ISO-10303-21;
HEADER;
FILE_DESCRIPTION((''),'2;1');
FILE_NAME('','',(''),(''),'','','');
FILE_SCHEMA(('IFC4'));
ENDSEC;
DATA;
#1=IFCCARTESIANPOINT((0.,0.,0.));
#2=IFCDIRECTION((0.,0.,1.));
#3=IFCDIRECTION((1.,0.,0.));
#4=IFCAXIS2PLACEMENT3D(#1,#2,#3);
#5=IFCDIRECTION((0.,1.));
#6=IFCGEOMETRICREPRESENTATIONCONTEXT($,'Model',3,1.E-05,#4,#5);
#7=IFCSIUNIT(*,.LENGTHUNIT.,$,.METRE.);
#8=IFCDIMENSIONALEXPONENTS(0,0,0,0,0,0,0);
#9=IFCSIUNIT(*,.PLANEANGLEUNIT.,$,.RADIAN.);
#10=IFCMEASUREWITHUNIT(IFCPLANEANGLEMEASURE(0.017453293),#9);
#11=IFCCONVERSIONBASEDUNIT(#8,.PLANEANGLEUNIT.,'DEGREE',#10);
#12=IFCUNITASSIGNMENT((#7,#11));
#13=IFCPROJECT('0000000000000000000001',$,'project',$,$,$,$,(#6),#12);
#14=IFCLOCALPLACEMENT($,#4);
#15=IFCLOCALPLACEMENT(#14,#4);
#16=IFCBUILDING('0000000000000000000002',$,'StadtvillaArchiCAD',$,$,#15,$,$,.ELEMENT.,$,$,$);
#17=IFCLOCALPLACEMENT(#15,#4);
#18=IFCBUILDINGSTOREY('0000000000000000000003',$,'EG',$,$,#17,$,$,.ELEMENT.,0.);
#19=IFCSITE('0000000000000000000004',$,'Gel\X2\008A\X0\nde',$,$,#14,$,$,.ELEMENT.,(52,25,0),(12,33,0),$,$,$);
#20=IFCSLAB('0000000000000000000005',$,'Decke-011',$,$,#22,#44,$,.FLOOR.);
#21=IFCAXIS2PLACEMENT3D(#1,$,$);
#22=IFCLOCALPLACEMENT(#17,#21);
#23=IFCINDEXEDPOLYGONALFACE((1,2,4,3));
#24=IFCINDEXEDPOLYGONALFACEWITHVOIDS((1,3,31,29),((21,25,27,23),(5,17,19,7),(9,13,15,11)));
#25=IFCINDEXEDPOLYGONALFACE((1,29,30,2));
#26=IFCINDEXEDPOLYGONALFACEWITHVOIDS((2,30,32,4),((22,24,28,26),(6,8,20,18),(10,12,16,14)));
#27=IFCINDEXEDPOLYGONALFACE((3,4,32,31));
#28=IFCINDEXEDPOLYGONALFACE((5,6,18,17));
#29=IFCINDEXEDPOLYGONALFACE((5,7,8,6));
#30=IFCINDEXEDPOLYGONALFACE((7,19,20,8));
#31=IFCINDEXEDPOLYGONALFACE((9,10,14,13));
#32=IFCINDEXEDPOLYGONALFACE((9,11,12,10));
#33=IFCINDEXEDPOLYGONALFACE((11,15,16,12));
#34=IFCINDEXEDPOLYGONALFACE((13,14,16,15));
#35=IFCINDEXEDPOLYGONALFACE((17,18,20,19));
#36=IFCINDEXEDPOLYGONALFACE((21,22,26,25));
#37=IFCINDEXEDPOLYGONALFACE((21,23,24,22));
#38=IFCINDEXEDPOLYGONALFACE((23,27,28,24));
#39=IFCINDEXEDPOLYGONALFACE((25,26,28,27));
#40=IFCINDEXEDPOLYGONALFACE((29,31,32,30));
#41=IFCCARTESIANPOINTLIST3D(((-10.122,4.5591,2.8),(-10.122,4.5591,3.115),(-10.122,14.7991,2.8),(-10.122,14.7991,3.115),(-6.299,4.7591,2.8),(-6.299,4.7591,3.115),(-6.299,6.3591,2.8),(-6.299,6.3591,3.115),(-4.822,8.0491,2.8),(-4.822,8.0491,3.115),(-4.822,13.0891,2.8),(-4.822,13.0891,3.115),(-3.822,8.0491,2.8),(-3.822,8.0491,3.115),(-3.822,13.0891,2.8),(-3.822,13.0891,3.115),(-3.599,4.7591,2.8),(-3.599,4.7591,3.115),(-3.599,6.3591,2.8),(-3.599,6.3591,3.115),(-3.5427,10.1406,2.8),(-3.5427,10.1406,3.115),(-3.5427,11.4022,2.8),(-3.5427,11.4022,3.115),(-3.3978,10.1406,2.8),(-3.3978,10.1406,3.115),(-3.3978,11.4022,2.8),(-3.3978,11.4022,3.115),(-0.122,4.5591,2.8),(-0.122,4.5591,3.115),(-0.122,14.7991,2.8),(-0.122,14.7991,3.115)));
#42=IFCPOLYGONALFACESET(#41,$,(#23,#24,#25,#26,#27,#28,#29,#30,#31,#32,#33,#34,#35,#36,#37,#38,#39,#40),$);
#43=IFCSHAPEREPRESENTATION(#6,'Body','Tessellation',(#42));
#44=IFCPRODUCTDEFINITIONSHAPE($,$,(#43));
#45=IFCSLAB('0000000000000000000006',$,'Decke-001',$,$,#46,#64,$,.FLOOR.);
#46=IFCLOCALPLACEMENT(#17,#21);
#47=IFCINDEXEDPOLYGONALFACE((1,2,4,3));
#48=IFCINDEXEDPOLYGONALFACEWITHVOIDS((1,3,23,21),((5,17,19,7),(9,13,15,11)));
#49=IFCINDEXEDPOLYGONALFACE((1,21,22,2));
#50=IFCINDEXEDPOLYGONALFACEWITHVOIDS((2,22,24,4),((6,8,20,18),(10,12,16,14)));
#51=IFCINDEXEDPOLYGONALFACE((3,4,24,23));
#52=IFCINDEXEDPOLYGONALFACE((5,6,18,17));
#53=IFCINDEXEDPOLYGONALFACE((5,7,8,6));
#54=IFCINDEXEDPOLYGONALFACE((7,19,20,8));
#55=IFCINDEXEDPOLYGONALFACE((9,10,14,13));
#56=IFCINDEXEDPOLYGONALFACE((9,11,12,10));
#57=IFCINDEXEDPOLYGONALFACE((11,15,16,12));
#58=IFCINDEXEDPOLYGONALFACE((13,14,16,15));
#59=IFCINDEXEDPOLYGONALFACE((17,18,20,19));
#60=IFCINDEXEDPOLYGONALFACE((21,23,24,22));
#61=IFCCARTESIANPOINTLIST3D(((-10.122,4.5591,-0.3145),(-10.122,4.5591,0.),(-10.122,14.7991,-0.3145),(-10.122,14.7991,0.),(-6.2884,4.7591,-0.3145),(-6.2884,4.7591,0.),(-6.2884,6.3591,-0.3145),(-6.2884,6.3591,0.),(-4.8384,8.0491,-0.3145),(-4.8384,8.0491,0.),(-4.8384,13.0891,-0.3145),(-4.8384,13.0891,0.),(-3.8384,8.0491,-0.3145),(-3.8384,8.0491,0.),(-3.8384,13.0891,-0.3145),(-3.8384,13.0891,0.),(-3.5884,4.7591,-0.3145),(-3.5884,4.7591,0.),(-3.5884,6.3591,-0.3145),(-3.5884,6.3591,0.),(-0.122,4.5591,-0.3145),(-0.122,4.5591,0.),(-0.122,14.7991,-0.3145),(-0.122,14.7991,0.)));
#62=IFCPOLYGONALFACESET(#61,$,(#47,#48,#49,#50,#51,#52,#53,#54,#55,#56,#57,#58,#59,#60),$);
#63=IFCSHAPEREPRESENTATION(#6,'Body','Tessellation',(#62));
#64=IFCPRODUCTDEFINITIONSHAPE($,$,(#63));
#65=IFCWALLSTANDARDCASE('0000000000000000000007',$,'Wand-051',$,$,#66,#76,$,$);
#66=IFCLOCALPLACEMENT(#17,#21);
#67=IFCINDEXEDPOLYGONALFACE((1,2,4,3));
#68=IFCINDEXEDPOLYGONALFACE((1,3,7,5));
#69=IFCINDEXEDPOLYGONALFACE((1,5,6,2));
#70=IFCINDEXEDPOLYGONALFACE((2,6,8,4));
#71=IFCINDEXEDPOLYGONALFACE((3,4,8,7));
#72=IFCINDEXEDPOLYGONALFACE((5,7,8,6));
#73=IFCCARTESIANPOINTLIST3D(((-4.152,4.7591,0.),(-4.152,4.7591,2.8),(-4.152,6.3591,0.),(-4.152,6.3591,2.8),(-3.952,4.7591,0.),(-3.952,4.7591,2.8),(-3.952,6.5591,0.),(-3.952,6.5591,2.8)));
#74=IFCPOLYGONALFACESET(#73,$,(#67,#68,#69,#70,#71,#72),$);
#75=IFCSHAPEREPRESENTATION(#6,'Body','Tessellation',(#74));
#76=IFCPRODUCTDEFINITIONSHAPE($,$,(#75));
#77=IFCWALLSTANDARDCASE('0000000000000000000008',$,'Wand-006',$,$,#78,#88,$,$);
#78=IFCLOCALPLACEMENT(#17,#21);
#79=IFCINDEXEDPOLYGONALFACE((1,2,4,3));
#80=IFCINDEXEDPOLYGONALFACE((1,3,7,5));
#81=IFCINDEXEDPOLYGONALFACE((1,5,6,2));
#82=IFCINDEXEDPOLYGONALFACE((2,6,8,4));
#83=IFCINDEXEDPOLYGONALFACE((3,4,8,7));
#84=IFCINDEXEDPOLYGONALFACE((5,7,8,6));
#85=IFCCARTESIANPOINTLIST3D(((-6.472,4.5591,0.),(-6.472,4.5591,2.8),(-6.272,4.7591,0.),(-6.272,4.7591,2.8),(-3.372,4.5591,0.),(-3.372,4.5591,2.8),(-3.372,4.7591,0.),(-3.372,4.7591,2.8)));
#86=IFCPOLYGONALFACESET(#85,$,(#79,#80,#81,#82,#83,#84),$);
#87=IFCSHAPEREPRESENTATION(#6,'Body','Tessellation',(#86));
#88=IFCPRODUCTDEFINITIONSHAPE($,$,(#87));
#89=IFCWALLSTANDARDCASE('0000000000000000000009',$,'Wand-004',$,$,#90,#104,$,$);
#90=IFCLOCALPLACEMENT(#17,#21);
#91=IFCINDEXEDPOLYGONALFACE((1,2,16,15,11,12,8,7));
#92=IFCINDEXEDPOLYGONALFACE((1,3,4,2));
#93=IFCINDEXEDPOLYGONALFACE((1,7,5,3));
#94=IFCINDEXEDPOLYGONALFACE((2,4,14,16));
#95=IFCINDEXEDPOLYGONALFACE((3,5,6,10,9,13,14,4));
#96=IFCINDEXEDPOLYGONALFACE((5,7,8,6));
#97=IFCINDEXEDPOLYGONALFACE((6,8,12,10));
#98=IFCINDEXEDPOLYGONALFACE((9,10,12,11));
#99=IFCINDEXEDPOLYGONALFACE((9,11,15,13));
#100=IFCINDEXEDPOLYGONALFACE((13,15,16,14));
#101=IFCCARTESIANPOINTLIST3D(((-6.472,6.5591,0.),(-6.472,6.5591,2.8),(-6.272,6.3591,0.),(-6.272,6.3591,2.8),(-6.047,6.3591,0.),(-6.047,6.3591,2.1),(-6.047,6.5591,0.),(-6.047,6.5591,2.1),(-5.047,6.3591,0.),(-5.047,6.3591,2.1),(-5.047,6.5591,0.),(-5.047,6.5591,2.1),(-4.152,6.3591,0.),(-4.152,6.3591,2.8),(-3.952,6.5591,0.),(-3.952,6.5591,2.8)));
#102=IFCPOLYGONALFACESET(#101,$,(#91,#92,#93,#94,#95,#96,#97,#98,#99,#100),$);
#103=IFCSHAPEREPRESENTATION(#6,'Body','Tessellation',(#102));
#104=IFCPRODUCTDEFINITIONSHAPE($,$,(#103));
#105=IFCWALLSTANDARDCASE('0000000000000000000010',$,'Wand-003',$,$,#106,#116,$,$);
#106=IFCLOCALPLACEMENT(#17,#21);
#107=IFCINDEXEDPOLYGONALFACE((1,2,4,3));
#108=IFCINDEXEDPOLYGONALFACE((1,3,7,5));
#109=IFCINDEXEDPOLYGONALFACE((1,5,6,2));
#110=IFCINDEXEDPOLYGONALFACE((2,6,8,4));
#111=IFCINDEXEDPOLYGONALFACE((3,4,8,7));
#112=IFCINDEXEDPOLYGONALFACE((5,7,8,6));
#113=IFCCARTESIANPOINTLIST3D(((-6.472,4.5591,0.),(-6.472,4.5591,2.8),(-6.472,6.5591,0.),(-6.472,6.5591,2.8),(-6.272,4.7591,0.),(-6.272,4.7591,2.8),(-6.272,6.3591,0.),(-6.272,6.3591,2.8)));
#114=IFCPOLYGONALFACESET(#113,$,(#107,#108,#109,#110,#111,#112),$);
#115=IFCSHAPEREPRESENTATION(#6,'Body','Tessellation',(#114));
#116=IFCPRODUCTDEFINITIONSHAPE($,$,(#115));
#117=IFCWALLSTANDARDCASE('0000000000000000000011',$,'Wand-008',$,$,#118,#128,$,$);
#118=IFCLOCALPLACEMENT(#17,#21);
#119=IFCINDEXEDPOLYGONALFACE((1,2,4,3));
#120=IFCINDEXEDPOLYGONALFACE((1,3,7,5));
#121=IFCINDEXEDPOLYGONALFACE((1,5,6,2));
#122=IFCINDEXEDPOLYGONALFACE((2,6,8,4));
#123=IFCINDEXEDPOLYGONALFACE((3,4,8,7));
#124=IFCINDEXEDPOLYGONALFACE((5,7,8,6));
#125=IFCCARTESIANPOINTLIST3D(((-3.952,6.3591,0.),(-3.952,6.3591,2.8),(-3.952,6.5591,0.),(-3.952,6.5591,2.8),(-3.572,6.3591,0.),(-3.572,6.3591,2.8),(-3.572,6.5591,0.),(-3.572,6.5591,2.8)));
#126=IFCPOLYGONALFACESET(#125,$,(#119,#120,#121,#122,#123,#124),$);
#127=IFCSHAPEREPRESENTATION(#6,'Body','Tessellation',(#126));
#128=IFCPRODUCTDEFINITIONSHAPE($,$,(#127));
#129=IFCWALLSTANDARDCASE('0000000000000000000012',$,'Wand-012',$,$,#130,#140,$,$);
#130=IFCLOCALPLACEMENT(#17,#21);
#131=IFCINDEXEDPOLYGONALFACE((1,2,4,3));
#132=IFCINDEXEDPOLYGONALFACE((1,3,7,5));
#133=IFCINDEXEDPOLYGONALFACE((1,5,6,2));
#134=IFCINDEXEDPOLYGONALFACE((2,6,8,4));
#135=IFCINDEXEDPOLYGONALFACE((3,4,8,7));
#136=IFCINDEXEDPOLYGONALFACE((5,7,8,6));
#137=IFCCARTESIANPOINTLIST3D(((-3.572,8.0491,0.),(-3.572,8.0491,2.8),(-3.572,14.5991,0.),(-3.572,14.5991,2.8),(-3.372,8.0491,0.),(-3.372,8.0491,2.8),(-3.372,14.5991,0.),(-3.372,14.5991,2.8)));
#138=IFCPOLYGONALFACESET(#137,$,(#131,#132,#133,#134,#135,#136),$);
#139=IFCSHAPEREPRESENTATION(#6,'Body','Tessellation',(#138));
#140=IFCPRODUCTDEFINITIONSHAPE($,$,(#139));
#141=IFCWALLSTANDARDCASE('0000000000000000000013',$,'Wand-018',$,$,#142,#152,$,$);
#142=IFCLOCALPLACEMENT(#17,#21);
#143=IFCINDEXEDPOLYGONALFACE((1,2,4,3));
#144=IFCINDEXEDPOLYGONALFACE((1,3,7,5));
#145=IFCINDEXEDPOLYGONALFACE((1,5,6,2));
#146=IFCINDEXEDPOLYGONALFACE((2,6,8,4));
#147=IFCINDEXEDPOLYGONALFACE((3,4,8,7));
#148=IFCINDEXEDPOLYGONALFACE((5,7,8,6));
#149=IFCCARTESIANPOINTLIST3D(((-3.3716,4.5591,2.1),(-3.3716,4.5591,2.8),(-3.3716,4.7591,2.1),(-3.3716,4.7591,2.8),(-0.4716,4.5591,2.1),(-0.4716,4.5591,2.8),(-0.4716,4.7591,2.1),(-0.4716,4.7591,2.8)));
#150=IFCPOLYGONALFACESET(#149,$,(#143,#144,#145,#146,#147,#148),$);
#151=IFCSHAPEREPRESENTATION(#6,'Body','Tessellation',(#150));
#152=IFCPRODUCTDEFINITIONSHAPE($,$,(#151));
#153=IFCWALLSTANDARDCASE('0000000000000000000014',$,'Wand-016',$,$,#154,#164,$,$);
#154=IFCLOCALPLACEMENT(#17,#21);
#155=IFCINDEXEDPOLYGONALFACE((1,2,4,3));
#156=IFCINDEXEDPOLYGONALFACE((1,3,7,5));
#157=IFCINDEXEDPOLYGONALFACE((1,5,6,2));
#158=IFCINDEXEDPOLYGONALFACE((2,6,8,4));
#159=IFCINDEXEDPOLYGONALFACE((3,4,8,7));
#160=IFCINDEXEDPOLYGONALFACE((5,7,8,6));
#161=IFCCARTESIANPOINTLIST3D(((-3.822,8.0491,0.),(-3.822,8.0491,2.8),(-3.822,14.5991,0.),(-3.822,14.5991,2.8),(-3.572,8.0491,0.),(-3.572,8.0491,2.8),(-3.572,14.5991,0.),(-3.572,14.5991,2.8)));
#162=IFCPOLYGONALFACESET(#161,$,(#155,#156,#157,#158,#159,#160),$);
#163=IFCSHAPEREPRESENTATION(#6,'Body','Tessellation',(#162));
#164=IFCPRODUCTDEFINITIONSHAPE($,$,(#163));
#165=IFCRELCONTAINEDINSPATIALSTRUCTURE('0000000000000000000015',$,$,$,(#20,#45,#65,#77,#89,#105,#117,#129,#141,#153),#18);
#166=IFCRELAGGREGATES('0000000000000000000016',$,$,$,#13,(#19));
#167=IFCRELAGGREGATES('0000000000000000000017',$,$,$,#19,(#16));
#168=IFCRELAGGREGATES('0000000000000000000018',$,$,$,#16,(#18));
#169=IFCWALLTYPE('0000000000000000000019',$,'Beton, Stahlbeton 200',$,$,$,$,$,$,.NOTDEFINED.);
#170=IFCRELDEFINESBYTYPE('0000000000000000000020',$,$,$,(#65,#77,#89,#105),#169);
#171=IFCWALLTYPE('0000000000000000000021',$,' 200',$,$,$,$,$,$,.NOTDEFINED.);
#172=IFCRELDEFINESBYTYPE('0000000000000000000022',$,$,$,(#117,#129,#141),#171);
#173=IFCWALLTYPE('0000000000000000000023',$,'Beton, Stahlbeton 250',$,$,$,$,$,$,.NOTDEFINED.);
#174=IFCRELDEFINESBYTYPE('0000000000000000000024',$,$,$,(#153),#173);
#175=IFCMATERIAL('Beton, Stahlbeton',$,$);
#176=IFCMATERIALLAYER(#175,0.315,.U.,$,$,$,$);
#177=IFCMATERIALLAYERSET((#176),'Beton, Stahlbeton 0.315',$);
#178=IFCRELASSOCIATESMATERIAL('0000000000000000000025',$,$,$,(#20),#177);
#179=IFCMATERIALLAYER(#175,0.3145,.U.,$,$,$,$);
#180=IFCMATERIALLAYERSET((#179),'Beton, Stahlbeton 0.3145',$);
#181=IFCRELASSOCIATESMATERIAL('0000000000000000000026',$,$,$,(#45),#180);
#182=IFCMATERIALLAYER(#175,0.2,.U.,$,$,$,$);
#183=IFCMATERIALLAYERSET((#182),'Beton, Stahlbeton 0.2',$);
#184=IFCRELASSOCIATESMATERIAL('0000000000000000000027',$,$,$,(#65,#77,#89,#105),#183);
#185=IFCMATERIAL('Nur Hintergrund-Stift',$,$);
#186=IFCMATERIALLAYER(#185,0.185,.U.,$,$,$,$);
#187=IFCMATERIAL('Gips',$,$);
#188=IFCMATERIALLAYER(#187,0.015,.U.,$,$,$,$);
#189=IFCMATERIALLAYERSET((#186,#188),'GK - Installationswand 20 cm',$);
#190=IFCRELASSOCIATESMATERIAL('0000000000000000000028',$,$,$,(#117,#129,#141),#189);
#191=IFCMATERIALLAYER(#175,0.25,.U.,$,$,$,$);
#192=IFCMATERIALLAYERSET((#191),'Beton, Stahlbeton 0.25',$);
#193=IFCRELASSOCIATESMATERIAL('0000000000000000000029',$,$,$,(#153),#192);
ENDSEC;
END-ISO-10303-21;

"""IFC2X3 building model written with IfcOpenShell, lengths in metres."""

from ifc_helpers import new_model, entity, si_unit, converted_unit, direction, frame, origin_with_axes, origin_2d_with_axis, place, context, project, spatial, polyline, rectangle, outline, extrude, material, layer, layer_set, layer_usage, type_object, element, save


model = new_model("IFC2X3")

# Units and contexts
model_context = context("Model", 3, precision=1e-05, world=origin_with_axes(), true_north=direction((0.0, 1.0)))
ifc_project = project(units=[si_unit("LENGTHUNIT", "METRE"), converted_unit("PLANEANGLEUNIT", "DEGREE", entity("IfcPlaneAngleMeasure", 0.017453293), si_unit("PLANEANGLEUNIT", "RADIAN"), dimensions=[0, 0, 0, 0, 0, 0, 0])], contexts=[model_context])

# Site, building, storey
site_placement = place(None, origin_with_axes())
site = spatial("IfcSite", under=ifc_project, at=site_placement, Name="Gel\u008ande", CompositionType="ELEMENT", RefLatitude=(52, 25, 0), RefLongitude=(12, 33, 0))
building_placement = place(site_placement, origin_with_axes())
building = spatial("IfcBuilding", under=site, at=building_placement, Name="StadtvillaArchiCAD", CompositionType="ELEMENT")
storey_placement = place(building_placement, origin_with_axes())
storey = spatial("IfcBuildingStorey", under=building, at=storey_placement, Name="EG", CompositionType="ELEMENT", Elevation=0.0)

# Slabs
ifc_material_1 = material(Name="Beton, Stahlbeton")
ifc_layer_1 = layer(ifc_material_1, 0.315, ventilated="UNKNOWN")
ifc_layer_set_1 = layer_set([ifc_layer_1], Name="Beton, Stahlbeton 0.315")
ifc_layer_usage_1 = layer_usage(ifc_layer_set_1, "AXIS3", "NEGATIVE", 0.315)
slab_1_placement = place(storey_placement, frame((-0.122, 14.7991, 2.8), z_axis=(0.0, 0.0, 1.0), x_axis=(1.0, 0.0, 0.0)))
element("IfcSlab", 1, at=slab_1_placement, inside=storey, material=ifc_layer_usage_1, Name="Decke-011", PredefinedType="FLOOR", context=model_context, shape_type="SweptSolid", body=[
    extrude(outline(polyline([(0.0, 0.0), (-10.0, 0.0), (-10.0, -10.24), (0.0, -10.24), (0.0, 0.0)]), holes=[polyline([(-4.7, -1.71), (-3.7, -1.71), (-3.7, -6.75), (-4.7, -6.75), (-4.7, -1.71)]), polyline([(-3.4208, -3.3969), (-3.2759, -3.3969), (-3.2759, -4.6585), (-3.4208, -4.6585), (-3.4208, -3.3969)]), polyline([(-6.1771, -8.44), (-3.4771, -8.44), (-3.4771, -10.04), (-6.1771, -10.04), (-6.1771, -8.44)])]), origin_with_axes(), (0.0, 0.0, 1.0), 0.315),
])
ifc_layer_2 = layer(ifc_material_1, 0.3145, ventilated="UNKNOWN")
ifc_layer_set_2 = layer_set([ifc_layer_2], Name="Beton, Stahlbeton 0.3145")
ifc_layer_usage_2 = layer_usage(ifc_layer_set_2, "AXIS3", "NEGATIVE", 0.3145)
slab_2_placement = place(storey_placement, frame((-10.122, 14.7991, -0.3145), z_axis=(0.0, 0.0, 1.0), x_axis=(1.0, 0.0, 0.0)))
element("IfcSlab", 2, at=slab_2_placement, inside=storey, material=ifc_layer_usage_2, Name="Decke-001", PredefinedType="FLOOR", context=model_context, shape_type="SweptSolid", body=[
    extrude(outline(polyline([(0.0, 0.0), (0.0, -10.24), (10.0, -10.24), (10.0, 0.0), (0.0, 0.0)]), holes=[polyline([(5.2835, -1.71), (6.2835, -1.71), (6.2835, -6.75), (5.2835, -6.75), (5.2835, -1.71)]), polyline([(3.8335, -8.44), (6.5335, -8.44), (6.5335, -10.04), (3.8335, -10.04), (3.8335, -8.44)])]), origin_with_axes(), (0.0, 0.0, 1.0), 0.3145),
])

# Walls
ifc_layer_3 = layer(ifc_material_1, 0.2, ventilated="UNKNOWN")
ifc_layer_set_3 = layer_set([ifc_layer_3], Name="Beton, Stahlbeton 0.2")
ifc_layer_usage_3 = layer_usage(ifc_layer_set_3, "AXIS2", "NEGATIVE", 0.0)
wall_type_1 = type_object("IfcWallType", Name="Beton, Stahlbeton 200", PredefinedType="NOTDEFINED")
wall_1_placement = place(storey_placement, frame((-3.952, 6.5591, 0.0), z_axis=(0.0, 0.0, 1.0), x_axis=(0.0, -1.0, 0.0)))
element("IfcWallStandardCase", 3, at=wall_1_placement, inside=storey, type_object=wall_type_1, material=ifc_layer_usage_3, Name="Wand-051", context=model_context, shape_type="SweptSolid", body=[
    extrude(outline(polyline([(0.2, -0.2), (1.8, -0.2), (1.8, 0.0), (0.0, 0.0), (0.2, -0.2)])), origin_with_axes(), (0.0, 0.0, 1.0), 2.8),
])
ifc_layer_usage_4 = layer_usage(ifc_layer_set_3, "AXIS2", "NEGATIVE", 0.0)
wall_2_placement = place(storey_placement, frame((-3.372, 4.5591, 0.0), z_axis=(0.0, 0.0, 1.0), x_axis=(-1.0, 0.0, 0.0)))
element("IfcWallStandardCase", 4, at=wall_2_placement, inside=storey, type_object=wall_type_1, material=ifc_layer_usage_4, Name="Wand-006", context=model_context, shape_type="SweptSolid", body=[
    extrude(outline(polyline([(0.0, -0.2), (2.9, -0.2), (3.1, 0.0), (0.0, 0.0), (0.0, -0.2)])), origin_with_axes(), (0.0, 0.0, 1.0), 2.8),
])

# Wall, opening
ifc_layer_usage_5 = layer_usage(ifc_layer_set_3, "AXIS2", "NEGATIVE", 0.0)
wall_3_placement = place(storey_placement, frame((-6.472, 6.5591, 0.0), z_axis=(0.0, 0.0, 1.0), x_axis=(1.0, 0.0, 0.0)))
wall_3 = element("IfcWallStandardCase", 5, at=wall_3_placement, inside=storey, type_object=wall_type_1, material=ifc_layer_usage_5, Name="Wand-004", context=model_context, shape_type="SweptSolid", body=[
    extrude(outline(polyline([(0.2, -0.2), (2.32, -0.2), (2.52, 0.0), (0.0, 0.0), (0.2, -0.2)])), origin_with_axes(), (0.0, 0.0, 1.0), 2.8),
])
opening_1_placement = place(wall_3_placement, frame((0.925, 0.0, 0.0), z_axis=(0.0, 0.0, 1.0), x_axis=(1.0, 0.0, 0.0)))
element("IfcOpeningElement", 6, at=opening_1_placement, cuts=wall_3, context=model_context, shape_type="SweptSolid", body=[
    extrude(rectangle(XDim=1.0, YDim=2.1, at=origin_2d_with_axis()), frame((0.0, -1.8, 1.05), z_axis=(0.0, 1.0, 0.0), x_axis=(1.0, 0.0, 0.0)), (0.0, 0.0, 1.0), 3.2),
])

# Wall
ifc_layer_usage_6 = layer_usage(ifc_layer_set_3, "AXIS2", "NEGATIVE", 0.0)
wall_4_placement = place(storey_placement, frame((-6.472, 4.5591, 0.0), z_axis=(0.0, 0.0, 1.0), x_axis=(0.0, 1.0, 0.0)))
element("IfcWallStandardCase", 7, at=wall_4_placement, inside=storey, type_object=wall_type_1, material=ifc_layer_usage_6, Name="Wand-003", context=model_context, shape_type="SweptSolid", body=[
    extrude(outline(polyline([(0.2, -0.2), (1.8, -0.2), (2.0, 0.0), (0.0, 0.0), (0.2, -0.2)])), origin_with_axes(), (0.0, 0.0, 1.0), 2.8),
])

# Walls
ifc_material_2 = material(Name="Nur Hintergrund-Stift")
ifc_layer_4 = layer(ifc_material_2, 0.185, ventilated="UNKNOWN")
ifc_material_3 = material(Name="Gips")
ifc_layer_5 = layer(ifc_material_3, 0.015, ventilated="UNKNOWN")
ifc_layer_set_4 = layer_set([ifc_layer_4, ifc_layer_5], Name="GK - Installationswand 20 cm")
wall_type_2 = type_object("IfcWallType", Name=" 200", PredefinedType="NOTDEFINED")
ifc_layer_usage_7 = layer_usage(ifc_layer_set_4, "AXIS2", "NEGATIVE", 0.0)
wall_5_placement = place(storey_placement, frame((-3.572, 6.3591, 0.0), z_axis=(0.0, 0.0, 1.0), x_axis=(-1.0, 0.0, 0.0)))
element("IfcWallStandardCase", 8, at=wall_5_placement, inside=storey, type_object=wall_type_2, material=ifc_layer_usage_7, Name="Wand-008", context=model_context, shape_type="SweptSolid", body=[
    extrude(outline(polyline([(0.0, -0.2), (0.38, -0.2), (0.38, 0.0), (0.0, 0.0), (0.0, -0.2)])), origin_with_axes(), (0.0, 0.0, 1.0), 2.8),
])
ifc_layer_usage_8 = layer_usage(ifc_layer_set_4, "AXIS2", "NEGATIVE", 0.0)
wall_6_placement = place(storey_placement, frame((-3.572, 8.0491, 0.0), z_axis=(0.0, 0.0, 1.0), x_axis=(0.0, 1.0, 0.0)))
element("IfcWallStandardCase", 9, at=wall_6_placement, inside=storey, type_object=wall_type_2, material=ifc_layer_usage_8, Name="Wand-012", context=model_context, shape_type="SweptSolid", body=[
    extrude(outline(polyline([(0.0, -0.2), (6.55, -0.2), (6.55, 0.0), (0.0, 0.0), (0.0, -0.2)])), origin_with_axes(), (0.0, 0.0, 1.0), 2.8),
])

# Wall, opening
ifc_layer_usage_9 = layer_usage(ifc_layer_set_4, "AXIS2", "NEGATIVE", 0.0)
wall_7_placement = place(storey_placement, frame((-3.3716, 4.7591, 0.0), z_axis=(0.0, 0.0, 1.0), x_axis=(1.0, 0.0, 0.0)))
wall_7 = element("IfcWallStandardCase", 10, at=wall_7_placement, inside=storey, type_object=wall_type_2, material=ifc_layer_usage_9, Name="Wand-018", context=model_context, shape_type="SweptSolid", body=[
    extrude(outline(polyline([(0.0, -0.2), (2.9, -0.2), (2.9, 0.0), (0.0, 0.0), (0.0, -0.2)])), origin_with_axes(), (0.0, 0.0, 1.0), 2.8),
])
opening_2_placement = place(wall_7_placement, frame((1.45, 0.0, 0.0), z_axis=(0.0, 0.0, 1.0), x_axis=(1.0, 0.0, 0.0)))
element("IfcOpeningElement", 11, at=opening_2_placement, cuts=wall_7, context=model_context, shape_type="SweptSolid", body=[
    extrude(rectangle(XDim=2.9, YDim=2.1, at=origin_2d_with_axis()), frame((0.0, 0.001, 1.05), z_axis=(0.0, -1.0, 0.0), x_axis=(1.0, 0.0, 0.0)), (0.0, 0.0, 1.0), 0.602),
])

# Wall
ifc_layer_6 = layer(ifc_material_1, 0.25, ventilated="UNKNOWN")
ifc_layer_set_5 = layer_set([ifc_layer_6], Name="Beton, Stahlbeton 0.25")
ifc_layer_usage_10 = layer_usage(ifc_layer_set_5, "AXIS2", "NEGATIVE", 0.0)
wall_type_3 = type_object("IfcWallType", Name="Beton, Stahlbeton 250", PredefinedType="NOTDEFINED")
wall_8_placement = place(storey_placement, frame((-3.822, 8.0491, 0.0), z_axis=(0.0, 0.0, 1.0), x_axis=(0.0, 1.0, 0.0)))
element("IfcWallStandardCase", 12, at=wall_8_placement, inside=storey, type_object=wall_type_3, material=ifc_layer_usage_10, Name="Wand-016", context=model_context, shape_type="SweptSolid", body=[
    extrude(outline(polyline([(0.0, -0.25), (6.55, -0.25), (6.55, 0.0), (0.0, 0.0), (0.0, -0.25)])), origin_with_axes(), (0.0, 0.0, 1.0), 2.8),
])

save(model, "model.ifc")
